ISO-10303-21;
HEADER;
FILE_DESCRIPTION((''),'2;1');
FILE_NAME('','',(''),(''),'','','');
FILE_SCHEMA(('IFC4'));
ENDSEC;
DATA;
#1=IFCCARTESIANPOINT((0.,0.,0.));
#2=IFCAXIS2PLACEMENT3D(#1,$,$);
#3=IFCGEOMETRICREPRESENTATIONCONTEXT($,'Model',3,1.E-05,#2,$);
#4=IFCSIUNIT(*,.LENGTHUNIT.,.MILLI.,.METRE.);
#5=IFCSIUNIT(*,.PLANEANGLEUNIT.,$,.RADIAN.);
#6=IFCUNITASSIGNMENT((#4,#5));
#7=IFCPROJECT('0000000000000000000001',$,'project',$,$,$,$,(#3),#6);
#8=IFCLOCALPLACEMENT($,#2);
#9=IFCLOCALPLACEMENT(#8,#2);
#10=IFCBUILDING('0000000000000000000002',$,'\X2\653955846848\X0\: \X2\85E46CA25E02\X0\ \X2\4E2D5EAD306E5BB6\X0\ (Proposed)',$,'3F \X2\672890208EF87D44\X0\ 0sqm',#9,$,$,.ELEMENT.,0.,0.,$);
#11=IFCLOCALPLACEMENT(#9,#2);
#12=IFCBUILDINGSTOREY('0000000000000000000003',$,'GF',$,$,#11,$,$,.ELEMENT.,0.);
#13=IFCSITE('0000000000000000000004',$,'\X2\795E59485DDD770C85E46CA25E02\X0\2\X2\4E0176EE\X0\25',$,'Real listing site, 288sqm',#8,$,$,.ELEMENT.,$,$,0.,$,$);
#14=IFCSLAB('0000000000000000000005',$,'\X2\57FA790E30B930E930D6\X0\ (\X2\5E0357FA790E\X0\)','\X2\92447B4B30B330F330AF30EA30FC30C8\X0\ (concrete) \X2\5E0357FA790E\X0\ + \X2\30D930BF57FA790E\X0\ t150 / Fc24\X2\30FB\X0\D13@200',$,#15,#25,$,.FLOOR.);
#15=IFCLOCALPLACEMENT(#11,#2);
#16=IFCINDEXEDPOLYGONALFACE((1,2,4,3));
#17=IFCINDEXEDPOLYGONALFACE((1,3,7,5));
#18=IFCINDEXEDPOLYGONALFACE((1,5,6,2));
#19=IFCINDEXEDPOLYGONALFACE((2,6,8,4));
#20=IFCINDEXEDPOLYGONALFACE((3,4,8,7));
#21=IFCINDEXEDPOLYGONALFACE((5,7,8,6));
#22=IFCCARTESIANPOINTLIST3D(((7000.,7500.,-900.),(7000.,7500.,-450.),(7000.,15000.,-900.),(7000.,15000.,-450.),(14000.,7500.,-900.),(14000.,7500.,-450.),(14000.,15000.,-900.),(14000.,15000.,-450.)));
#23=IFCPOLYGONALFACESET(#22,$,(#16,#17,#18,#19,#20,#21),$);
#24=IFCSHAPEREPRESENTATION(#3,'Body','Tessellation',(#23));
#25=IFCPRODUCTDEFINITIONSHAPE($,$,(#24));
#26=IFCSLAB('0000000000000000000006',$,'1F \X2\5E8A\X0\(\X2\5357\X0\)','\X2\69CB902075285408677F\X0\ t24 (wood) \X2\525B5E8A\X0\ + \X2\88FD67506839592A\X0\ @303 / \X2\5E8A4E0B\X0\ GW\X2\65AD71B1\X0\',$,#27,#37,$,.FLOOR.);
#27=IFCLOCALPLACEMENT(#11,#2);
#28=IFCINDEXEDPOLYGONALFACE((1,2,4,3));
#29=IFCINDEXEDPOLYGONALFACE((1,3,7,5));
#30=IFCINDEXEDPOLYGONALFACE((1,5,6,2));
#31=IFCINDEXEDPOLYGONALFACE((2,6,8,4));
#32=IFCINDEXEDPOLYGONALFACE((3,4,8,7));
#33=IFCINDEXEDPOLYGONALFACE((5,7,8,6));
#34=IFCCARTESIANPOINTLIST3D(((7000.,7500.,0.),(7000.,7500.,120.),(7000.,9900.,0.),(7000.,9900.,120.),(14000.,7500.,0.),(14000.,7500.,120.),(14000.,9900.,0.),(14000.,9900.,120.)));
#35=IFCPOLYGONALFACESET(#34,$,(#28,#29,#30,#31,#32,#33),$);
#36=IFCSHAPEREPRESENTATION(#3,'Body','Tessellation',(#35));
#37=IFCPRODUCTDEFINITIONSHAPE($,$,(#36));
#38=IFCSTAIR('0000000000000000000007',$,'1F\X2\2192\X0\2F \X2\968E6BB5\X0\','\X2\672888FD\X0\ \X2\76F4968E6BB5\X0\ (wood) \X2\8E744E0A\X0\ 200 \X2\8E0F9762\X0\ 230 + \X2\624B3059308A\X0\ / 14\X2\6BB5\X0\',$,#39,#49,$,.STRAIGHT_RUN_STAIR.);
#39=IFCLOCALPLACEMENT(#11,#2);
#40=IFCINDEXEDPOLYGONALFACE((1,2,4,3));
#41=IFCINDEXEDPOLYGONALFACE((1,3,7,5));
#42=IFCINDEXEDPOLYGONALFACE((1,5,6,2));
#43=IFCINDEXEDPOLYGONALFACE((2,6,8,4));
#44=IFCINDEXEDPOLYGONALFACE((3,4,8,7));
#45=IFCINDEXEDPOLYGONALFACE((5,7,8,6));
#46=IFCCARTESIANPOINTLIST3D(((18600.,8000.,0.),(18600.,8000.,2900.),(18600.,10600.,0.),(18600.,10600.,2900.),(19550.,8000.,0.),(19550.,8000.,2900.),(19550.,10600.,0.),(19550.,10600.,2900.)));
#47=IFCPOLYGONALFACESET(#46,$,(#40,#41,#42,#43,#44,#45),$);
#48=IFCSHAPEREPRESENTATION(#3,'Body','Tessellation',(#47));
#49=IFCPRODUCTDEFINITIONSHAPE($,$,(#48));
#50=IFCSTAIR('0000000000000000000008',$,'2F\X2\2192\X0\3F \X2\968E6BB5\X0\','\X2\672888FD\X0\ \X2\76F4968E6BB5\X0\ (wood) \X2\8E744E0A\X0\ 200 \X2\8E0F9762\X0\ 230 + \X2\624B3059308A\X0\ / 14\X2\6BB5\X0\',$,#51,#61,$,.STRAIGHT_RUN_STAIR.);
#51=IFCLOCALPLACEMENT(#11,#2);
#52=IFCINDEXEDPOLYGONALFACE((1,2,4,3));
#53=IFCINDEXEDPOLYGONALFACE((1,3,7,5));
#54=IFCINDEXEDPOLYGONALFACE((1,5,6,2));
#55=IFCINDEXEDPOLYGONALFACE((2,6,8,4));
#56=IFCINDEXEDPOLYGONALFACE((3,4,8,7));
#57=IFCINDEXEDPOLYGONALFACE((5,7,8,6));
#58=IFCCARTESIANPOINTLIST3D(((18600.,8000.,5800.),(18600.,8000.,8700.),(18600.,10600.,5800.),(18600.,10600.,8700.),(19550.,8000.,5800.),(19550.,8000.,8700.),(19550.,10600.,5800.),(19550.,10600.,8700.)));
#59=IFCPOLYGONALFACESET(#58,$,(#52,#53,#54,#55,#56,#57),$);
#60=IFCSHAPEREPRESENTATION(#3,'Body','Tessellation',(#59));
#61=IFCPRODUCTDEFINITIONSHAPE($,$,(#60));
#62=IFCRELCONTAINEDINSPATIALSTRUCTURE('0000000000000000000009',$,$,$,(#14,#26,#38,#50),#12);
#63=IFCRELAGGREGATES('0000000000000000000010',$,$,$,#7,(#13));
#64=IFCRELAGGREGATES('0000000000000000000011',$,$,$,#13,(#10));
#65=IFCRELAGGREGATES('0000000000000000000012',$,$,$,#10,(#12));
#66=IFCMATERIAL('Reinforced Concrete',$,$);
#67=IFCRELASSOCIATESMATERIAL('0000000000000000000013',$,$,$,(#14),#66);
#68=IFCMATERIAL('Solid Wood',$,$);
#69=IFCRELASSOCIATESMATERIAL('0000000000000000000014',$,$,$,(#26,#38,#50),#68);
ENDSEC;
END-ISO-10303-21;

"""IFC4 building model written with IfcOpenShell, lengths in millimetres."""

from ifc_helpers import new_model, si_unit, frame, frame_2d, origin, place, context, project, spatial, rectangle, extrude, material, element, save


model = new_model("IFC4")

# Units and contexts
model_context = context("Model", 3, precision=1e-05, world=origin())
ifc_project = project(units=[si_unit("LENGTHUNIT", "METRE", prefix="MILLI"), si_unit("PLANEANGLEUNIT", "RADIAN")], contexts=[model_context])

# Site, building, storey
site_placement = place(None, origin())
site = spatial("IfcSite", under=ifc_project, at=site_placement, Name="神奈川県藤沢市2丁目25", ObjectType="Real listing site, 288sqm", CompositionType="ELEMENT", RefElevation=0.0)
building_placement = place(site_placement, origin())
building = spatial("IfcBuilding", under=site, at=building_placement, Name="改善案: 藤沢市 中庭の家 (Proposed)", ObjectType="3F 木造軸組 0sqm", CompositionType="ELEMENT", ElevationOfRefHeight=0.0, ElevationOfTerrain=0.0)
storey_placement = place(building_placement, origin())
storey = spatial("IfcBuildingStorey", under=building, at=storey_placement, Name="GF", CompositionType="ELEMENT", Elevation=0.0)

# Slabs
ifc_material_1 = material(Name="Reinforced Concrete")
slab_1_placement = place(storey_placement, frame((3500.0, 3750.0, -450.0)))
element("IfcSlab", 1, at=slab_1_placement, inside=storey, material=ifc_material_1, Name="基礎スラブ (布基礎)", Description="鉄筋コンクリート (concrete) 布基礎 + ベタ基礎 t150 / Fc24・D13@200", PredefinedType="FLOOR", context=model_context, shape_type="SweptSolid", body=[
    extrude(rectangle(XDim=7000.0, YDim=7500.0, at=frame_2d((3500.0, 3750.0))), frame((3500.0, 3750.0, -450.0)), (0.0, 0.0, 1.0), 450.0),
])
ifc_material_2 = material(Name="Solid Wood")
slab_2_placement = place(storey_placement, frame((3500.0, 3750.0, 0.0)))
element("IfcSlab", 2, at=slab_2_placement, inside=storey, material=ifc_material_2, Name="1F 床(南)", Description="構造用合板 t24 (wood) 剛床 + 製材根太 @303 / 床下 GW断熱", PredefinedType="FLOOR", context=model_context, shape_type="SweptSolid", body=[
    extrude(rectangle(XDim=7000.0, YDim=2400.0, at=frame_2d((3500.0, 1200.0))), frame((3500.0, 3750.0, 0.0)), (0.0, 0.0, 1.0), 120.0),
])

# Stairs
stair_1_placement = place(storey_placement, frame((9300.0, 4000.0, 0.0)))
element("IfcStair", 3, at=stair_1_placement, inside=storey, material=ifc_material_2, Name="1F→2F 階段", Description="木製 直階段 (wood) 蹴上 200 踏面 230 + 手すり / 14段", PredefinedType="STRAIGHT_RUN_STAIR", context=model_context, shape_type="SweptSolid", body=[
    extrude(rectangle(XDim=950.0, YDim=2600.0, at=frame_2d((475.0, 1300.0))), frame((9300.0, 4000.0, 0.0)), (0.0, 0.0, 1.0), 2900.0),
])
stair_2_placement = place(storey_placement, frame((9300.0, 4000.0, 2900.0)))
element("IfcStair", 4, at=stair_2_placement, inside=storey, material=ifc_material_2, Name="2F→3F 階段", Description="木製 直階段 (wood) 蹴上 200 踏面 230 + 手すり / 14段", PredefinedType="STRAIGHT_RUN_STAIR", context=model_context, shape_type="SweptSolid", body=[
    extrude(rectangle(XDim=950.0, YDim=2600.0, at=frame_2d((475.0, 1300.0))), frame((9300.0, 4000.0, 2900.0)), (0.0, 0.0, 1.0), 2900.0),
])

save(model, "model.ifc")
